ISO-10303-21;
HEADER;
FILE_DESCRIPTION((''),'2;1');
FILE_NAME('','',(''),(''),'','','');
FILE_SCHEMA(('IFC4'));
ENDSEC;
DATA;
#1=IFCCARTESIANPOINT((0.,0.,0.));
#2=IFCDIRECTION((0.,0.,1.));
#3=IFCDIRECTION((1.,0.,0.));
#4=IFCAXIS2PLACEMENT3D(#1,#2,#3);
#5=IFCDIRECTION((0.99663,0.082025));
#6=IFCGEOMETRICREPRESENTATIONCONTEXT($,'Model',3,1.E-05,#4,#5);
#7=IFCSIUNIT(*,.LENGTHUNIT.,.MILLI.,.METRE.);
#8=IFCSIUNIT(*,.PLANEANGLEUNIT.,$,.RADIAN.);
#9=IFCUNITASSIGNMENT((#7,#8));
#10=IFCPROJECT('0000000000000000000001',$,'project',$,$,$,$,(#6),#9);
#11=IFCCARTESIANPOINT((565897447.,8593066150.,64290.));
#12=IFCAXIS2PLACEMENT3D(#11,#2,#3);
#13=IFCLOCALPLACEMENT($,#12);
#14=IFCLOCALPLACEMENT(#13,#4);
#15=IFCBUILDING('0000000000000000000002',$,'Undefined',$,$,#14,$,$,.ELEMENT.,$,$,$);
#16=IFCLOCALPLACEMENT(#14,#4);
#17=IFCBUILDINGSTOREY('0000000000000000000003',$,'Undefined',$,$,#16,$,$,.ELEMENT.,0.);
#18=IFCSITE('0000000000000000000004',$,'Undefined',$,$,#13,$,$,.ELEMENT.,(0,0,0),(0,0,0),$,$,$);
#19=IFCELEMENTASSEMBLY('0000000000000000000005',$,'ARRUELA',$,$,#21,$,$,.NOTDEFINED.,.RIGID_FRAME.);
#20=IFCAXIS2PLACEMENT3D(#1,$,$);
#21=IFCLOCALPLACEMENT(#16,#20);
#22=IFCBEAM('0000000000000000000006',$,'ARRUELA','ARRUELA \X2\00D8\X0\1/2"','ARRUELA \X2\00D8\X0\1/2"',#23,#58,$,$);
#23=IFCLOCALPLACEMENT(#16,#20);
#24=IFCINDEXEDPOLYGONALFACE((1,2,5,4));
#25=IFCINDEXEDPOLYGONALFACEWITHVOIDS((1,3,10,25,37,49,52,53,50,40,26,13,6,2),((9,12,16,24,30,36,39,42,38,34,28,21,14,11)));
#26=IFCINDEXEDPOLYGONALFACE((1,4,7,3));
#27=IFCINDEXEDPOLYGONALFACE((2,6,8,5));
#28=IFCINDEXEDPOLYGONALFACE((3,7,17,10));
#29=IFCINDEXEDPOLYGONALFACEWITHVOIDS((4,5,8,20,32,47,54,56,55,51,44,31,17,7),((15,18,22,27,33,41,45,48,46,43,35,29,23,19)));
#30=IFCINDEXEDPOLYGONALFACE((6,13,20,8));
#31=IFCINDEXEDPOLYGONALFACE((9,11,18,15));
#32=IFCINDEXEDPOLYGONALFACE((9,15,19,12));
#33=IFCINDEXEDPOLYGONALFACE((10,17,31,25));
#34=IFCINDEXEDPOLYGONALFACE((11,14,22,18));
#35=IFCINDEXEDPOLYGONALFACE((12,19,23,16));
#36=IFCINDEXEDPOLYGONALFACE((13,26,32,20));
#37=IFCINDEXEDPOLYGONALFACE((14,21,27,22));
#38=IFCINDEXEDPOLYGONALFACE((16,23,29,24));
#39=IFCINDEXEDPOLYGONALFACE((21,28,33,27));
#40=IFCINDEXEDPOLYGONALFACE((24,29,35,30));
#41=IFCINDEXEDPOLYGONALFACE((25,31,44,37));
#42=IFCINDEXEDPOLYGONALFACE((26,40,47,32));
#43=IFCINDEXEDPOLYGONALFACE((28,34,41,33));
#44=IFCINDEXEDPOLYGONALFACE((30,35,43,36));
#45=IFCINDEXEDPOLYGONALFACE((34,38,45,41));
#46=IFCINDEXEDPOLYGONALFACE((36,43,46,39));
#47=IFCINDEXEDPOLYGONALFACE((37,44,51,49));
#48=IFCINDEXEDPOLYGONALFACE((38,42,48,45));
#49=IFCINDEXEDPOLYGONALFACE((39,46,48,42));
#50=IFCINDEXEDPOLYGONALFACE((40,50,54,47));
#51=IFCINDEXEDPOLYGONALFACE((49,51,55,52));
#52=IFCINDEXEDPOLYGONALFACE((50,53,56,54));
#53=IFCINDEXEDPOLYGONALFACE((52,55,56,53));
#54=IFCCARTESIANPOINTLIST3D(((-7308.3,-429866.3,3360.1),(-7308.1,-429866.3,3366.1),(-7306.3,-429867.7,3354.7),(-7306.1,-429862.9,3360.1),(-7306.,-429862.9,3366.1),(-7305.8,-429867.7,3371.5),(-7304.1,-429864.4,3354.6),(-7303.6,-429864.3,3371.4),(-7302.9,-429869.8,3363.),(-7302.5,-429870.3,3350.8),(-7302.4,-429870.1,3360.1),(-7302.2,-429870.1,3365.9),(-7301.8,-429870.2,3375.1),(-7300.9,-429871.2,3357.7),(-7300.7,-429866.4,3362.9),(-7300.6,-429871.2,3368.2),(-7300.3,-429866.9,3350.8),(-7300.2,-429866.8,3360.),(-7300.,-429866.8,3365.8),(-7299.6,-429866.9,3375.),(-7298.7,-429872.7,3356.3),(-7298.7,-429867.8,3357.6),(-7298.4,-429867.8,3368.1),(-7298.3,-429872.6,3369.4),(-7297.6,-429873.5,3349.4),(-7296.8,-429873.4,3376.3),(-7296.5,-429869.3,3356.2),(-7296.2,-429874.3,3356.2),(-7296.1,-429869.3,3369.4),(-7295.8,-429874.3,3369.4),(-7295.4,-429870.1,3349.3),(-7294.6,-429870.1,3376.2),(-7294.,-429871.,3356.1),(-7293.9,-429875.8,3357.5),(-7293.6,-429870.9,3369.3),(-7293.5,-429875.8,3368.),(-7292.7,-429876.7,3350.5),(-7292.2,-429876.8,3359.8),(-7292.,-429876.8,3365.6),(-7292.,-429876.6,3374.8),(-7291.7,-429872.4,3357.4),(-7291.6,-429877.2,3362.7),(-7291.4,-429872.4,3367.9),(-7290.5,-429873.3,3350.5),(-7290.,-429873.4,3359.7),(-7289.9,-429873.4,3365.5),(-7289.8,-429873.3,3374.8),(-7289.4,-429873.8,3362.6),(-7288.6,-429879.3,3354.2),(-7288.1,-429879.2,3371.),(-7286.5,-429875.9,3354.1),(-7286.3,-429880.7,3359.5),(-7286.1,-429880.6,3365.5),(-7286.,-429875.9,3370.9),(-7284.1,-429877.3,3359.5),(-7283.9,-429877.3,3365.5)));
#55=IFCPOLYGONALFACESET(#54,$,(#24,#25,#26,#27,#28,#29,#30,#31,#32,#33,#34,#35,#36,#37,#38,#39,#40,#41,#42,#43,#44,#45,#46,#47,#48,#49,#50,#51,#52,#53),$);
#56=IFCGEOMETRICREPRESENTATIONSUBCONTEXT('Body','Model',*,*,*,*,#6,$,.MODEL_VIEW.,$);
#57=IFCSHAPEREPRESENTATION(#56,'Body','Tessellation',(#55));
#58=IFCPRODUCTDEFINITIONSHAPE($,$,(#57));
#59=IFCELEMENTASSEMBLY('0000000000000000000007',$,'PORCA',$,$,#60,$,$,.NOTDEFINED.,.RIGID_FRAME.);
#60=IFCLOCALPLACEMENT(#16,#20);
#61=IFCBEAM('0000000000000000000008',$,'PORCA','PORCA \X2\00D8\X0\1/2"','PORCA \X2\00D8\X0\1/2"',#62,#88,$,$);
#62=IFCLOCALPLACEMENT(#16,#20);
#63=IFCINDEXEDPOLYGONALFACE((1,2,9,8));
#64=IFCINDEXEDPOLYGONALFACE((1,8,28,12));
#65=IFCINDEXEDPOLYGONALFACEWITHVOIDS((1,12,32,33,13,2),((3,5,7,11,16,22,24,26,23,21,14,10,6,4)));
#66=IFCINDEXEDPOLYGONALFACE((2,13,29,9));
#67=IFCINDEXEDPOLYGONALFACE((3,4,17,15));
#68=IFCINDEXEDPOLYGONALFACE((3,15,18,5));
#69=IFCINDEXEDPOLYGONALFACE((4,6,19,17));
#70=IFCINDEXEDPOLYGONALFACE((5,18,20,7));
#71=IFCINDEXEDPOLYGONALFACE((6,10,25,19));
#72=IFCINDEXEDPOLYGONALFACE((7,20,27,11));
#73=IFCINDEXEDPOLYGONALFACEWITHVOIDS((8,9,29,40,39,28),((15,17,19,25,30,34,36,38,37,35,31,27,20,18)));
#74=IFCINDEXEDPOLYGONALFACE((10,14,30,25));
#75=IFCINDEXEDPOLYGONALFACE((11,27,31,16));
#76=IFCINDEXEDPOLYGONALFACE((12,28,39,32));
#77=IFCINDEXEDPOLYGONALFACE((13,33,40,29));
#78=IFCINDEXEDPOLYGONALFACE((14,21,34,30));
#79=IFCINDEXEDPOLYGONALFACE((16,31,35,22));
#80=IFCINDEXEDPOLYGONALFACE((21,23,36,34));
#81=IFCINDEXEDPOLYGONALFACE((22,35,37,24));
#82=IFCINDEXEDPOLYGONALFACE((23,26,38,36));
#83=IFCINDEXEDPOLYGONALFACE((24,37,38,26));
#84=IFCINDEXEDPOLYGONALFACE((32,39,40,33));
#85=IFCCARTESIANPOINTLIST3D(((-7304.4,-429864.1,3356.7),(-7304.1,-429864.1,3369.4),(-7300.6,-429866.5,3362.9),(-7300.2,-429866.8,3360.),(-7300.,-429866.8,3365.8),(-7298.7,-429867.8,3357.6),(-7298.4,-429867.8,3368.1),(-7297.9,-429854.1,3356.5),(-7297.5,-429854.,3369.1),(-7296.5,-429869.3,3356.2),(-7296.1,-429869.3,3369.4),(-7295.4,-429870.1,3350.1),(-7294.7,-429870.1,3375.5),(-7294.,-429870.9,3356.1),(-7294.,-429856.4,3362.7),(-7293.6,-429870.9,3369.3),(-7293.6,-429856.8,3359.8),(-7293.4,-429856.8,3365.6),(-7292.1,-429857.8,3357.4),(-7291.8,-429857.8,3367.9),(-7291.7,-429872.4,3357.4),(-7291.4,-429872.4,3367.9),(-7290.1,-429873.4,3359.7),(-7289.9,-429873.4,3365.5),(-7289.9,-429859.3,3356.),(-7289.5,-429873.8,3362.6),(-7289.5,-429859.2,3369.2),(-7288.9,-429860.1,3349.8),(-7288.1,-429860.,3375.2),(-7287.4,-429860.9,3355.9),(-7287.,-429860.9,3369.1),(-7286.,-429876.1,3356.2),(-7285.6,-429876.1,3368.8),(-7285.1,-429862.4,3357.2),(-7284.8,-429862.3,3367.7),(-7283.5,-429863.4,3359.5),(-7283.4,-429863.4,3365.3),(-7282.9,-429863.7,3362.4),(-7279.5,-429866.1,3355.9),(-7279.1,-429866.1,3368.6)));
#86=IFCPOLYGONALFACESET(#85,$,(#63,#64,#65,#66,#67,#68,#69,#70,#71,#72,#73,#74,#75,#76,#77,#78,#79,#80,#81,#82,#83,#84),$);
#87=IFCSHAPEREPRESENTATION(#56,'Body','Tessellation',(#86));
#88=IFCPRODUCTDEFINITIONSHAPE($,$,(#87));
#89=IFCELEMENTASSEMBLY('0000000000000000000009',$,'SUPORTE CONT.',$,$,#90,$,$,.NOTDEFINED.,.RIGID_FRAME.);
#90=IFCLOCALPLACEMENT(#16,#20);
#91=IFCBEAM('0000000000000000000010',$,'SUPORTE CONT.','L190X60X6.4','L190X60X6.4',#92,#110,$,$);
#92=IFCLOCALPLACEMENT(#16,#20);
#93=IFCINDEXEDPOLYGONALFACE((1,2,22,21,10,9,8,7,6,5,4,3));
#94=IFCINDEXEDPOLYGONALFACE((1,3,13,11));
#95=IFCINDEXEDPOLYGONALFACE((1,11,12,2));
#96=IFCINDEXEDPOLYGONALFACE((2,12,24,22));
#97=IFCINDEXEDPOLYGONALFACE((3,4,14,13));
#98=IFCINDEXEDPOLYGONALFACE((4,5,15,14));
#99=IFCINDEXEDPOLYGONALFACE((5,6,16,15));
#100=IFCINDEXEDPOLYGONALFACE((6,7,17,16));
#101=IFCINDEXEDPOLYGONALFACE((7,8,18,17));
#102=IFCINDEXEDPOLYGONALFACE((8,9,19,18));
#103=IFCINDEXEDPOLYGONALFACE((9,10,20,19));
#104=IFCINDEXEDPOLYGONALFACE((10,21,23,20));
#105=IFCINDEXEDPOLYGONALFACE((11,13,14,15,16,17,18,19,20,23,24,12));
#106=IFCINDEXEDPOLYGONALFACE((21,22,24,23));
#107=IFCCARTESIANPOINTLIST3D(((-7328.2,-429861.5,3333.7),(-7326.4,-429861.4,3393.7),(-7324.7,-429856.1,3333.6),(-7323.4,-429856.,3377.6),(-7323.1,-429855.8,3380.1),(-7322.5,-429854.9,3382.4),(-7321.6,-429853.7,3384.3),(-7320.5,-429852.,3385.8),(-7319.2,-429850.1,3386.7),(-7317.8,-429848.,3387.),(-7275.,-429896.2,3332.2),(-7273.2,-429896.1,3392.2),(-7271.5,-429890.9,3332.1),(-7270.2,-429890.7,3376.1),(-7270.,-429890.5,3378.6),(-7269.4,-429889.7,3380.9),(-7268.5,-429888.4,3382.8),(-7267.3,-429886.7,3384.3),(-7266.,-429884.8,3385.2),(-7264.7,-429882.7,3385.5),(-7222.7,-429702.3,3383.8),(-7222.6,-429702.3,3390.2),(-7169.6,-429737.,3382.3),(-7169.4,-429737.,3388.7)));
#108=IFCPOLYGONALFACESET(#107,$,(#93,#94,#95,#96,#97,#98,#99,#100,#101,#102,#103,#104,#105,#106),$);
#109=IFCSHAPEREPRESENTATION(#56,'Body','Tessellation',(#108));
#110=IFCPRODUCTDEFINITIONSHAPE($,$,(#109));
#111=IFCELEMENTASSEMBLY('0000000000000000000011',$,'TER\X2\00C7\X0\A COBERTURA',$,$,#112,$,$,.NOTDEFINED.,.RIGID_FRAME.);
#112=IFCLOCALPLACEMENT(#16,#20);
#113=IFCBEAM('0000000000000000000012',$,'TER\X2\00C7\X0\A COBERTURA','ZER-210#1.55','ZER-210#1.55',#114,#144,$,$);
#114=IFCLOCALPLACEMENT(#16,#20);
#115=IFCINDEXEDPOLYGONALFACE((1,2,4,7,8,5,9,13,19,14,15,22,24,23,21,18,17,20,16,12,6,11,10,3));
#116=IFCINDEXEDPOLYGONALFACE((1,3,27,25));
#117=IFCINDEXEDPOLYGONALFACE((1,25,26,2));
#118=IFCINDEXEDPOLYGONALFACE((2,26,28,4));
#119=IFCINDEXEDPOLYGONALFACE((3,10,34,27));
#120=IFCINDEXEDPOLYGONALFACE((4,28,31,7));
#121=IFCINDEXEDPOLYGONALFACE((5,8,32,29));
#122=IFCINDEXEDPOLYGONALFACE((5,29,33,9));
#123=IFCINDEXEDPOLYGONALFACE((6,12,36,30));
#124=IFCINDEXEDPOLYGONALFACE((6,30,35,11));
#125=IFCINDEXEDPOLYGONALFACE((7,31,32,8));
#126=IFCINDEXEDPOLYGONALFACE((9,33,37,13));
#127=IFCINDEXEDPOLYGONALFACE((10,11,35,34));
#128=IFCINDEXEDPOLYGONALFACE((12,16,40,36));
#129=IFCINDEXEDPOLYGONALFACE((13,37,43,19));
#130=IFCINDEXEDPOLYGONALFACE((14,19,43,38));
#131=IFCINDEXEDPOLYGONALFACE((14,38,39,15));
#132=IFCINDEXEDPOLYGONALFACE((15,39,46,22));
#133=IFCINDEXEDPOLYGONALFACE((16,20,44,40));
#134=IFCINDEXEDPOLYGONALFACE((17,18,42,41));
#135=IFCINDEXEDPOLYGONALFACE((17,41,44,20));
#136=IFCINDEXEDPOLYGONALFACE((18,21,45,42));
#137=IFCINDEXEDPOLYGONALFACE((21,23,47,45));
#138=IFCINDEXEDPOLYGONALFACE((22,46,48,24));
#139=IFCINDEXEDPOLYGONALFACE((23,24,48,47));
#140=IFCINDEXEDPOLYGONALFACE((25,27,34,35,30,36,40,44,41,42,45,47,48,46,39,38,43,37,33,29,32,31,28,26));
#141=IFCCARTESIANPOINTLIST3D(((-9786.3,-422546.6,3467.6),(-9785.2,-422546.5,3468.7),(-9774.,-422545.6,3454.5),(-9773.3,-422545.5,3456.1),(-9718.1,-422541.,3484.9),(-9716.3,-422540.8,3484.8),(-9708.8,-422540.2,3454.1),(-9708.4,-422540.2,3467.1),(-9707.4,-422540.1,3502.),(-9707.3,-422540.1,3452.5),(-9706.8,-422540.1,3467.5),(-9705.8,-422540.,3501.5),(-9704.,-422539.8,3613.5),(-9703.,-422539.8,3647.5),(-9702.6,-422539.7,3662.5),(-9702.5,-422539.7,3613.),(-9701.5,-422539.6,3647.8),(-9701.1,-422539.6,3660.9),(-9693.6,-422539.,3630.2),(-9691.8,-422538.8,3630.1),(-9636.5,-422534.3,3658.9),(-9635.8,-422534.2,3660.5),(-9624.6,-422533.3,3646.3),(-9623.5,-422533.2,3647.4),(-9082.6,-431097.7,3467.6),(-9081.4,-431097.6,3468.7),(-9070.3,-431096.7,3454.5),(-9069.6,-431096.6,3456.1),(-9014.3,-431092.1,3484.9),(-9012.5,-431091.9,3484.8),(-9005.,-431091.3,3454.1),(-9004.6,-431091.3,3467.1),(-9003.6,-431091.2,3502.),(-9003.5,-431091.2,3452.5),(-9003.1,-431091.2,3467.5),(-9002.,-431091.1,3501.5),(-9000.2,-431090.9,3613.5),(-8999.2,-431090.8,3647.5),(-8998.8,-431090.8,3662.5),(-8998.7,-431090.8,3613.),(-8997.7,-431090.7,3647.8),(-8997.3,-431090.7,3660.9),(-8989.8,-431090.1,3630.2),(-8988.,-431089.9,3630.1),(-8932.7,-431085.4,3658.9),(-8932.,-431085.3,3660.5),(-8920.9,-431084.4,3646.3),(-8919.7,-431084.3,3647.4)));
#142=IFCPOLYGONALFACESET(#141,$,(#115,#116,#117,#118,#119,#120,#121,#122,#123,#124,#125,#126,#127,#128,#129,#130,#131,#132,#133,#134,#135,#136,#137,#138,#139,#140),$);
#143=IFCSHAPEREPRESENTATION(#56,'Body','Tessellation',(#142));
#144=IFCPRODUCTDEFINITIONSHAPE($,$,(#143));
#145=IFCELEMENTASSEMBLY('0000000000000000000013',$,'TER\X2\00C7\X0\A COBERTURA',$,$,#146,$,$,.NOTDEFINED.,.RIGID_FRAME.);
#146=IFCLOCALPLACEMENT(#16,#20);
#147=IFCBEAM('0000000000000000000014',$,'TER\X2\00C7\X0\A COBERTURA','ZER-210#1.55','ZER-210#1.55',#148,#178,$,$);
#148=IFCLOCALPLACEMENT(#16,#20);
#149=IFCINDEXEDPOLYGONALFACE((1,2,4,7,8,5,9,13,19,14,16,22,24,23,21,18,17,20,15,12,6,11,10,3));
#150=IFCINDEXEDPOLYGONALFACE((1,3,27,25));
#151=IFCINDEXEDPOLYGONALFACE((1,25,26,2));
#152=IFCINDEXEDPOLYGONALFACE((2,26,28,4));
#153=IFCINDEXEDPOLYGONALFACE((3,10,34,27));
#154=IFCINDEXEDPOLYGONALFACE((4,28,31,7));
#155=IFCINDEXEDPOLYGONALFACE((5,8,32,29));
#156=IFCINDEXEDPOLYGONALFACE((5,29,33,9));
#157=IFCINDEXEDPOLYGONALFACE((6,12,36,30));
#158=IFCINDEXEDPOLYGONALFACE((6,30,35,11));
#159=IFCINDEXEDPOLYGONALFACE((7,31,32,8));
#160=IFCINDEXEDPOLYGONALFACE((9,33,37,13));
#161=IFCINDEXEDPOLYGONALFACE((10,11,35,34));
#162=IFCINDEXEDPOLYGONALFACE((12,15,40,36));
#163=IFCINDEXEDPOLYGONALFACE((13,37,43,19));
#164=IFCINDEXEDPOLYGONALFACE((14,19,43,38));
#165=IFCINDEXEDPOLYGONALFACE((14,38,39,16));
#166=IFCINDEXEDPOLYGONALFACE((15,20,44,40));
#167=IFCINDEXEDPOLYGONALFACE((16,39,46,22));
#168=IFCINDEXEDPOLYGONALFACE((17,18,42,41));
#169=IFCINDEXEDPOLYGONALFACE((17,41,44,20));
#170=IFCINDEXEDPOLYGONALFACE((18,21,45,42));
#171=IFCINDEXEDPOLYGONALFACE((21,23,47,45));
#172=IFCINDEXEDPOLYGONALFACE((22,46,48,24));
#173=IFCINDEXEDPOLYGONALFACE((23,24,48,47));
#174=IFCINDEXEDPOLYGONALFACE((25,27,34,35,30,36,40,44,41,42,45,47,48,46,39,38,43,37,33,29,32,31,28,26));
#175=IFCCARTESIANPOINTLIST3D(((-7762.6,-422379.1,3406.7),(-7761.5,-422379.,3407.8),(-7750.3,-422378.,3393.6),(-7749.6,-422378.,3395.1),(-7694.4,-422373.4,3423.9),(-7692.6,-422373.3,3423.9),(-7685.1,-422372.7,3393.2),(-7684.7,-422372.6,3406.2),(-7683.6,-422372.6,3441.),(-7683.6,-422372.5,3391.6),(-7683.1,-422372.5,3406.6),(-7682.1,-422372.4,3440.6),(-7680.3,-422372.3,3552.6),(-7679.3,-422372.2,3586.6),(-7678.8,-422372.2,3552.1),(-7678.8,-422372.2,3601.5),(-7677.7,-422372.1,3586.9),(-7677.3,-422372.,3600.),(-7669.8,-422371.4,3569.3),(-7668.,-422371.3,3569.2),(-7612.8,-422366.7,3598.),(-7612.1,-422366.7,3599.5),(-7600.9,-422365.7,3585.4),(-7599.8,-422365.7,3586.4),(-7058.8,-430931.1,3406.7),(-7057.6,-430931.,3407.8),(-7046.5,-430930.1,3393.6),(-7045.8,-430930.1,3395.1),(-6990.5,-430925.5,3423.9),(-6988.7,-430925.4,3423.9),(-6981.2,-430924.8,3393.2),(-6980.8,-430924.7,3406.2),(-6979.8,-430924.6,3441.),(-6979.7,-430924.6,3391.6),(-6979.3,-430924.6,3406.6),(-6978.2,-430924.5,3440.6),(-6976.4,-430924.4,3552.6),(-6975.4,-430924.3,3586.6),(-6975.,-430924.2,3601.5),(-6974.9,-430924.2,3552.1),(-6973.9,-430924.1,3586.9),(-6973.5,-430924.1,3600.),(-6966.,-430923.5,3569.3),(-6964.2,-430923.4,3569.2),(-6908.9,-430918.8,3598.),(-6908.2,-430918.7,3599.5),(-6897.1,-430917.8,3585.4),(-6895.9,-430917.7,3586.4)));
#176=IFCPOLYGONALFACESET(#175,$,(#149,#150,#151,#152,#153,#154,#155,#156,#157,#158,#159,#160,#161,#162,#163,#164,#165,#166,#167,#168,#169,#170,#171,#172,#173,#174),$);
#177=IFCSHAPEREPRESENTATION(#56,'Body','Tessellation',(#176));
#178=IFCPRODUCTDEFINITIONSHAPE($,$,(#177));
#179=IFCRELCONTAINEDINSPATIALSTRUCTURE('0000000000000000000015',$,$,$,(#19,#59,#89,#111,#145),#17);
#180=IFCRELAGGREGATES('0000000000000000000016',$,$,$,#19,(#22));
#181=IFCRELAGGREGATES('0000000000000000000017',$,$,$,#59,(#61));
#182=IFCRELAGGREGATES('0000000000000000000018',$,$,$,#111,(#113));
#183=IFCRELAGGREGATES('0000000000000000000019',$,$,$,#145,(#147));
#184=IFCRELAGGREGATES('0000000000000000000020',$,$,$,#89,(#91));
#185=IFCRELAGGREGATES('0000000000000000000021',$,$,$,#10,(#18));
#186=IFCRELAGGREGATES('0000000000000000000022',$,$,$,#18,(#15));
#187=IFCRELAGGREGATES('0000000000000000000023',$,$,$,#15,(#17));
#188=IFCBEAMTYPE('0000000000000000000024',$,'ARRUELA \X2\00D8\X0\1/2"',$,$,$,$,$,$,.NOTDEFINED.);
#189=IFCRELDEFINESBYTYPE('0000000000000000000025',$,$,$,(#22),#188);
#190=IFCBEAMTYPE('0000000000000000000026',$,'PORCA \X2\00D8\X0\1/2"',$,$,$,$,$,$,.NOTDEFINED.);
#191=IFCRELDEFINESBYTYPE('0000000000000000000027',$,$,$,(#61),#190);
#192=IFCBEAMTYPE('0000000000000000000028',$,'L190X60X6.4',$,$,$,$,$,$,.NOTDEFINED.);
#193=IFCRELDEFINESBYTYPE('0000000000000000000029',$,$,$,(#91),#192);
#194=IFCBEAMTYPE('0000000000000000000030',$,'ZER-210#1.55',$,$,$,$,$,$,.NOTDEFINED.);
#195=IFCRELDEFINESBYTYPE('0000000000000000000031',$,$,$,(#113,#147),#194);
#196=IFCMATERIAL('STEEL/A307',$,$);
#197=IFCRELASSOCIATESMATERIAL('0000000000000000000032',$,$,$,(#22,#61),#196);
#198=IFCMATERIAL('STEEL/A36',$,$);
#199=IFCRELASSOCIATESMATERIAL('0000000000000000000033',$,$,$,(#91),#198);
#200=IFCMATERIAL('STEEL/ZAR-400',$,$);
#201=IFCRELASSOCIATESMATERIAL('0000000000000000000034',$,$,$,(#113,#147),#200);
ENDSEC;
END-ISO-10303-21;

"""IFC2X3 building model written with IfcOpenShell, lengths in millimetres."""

from ifc_helpers import new_model, si_unit, direction, frame, origin_with_axes, origin_2d_with_axis, place, context, subcontext, project, spatial, polyline, l_section, outline, extrude, material, type_object, element, aggregate, save


model = new_model("IFC2X3")

# Units and contexts
model_context = context("Model", 3, precision=1e-05, world=origin_with_axes(), true_north=direction((0.99663, 0.082025)))
body_context = subcontext(model_context, "Body", "Model", "MODEL_VIEW")
ifc_project = project(units=[si_unit("LENGTHUNIT", "METRE", prefix="MILLI"), si_unit("PLANEANGLEUNIT", "RADIAN")], contexts=[model_context])

# Site, building, storey
site_placement = place(None, frame((565897447.0, 8593066150.0, 64290.0), z_axis=(0.0, 0.0, 1.0), x_axis=(1.0, 0.0, 0.0)))
site = spatial("IfcSite", under=ifc_project, at=site_placement, Name="Undefined", CompositionType="ELEMENT", RefLatitude=(0, 0, 0), RefLongitude=(0, 0, 0))
building_placement = place(site_placement, origin_with_axes())
building = spatial("IfcBuilding", under=site, at=building_placement, Name="Undefined", CompositionType="ELEMENT")
storey_placement = place(building_placement, origin_with_axes())
storey = spatial("IfcBuildingStorey", under=building, at=storey_placement, Name="Undefined", CompositionType="ELEMENT", Elevation=0.0)

# Element assemblies, beams
ifc_material_1 = material(Name="STEEL/ZAR-400")
ifc_material_2 = material(Name="STEEL/A36")
assembly_1_placement = place(storey_placement, origin_with_axes())
assembly_1 = element("IfcElementAssembly", 1, at=assembly_1_placement, inside=storey, Name="ARRUELA", AssemblyPlace="NOTDEFINED", PredefinedType="RIGID_FRAME")
ifc_material_3 = material(Name="STEEL/A307")
beam_type_1 = type_object("IfcBeamType", Name="ARRUELA Ø1/2\"", PredefinedType="NOTDEFINED")
beam_1_placement = place(assembly_1_placement, frame((-7295.0, -429870.1, 3362.8), z_axis=(-0.836984, 0.546715, 0.02368), x_axis=(-0.546411, -0.837315, 0.018398)))
beam_1 = element("IfcBeam", 2, at=beam_1_placement, type_object=beam_type_1, material=ifc_material_3, Name="ARRUELA", Description="ARRUELA Ø1/2\"", ObjectType="ARRUELA Ø1/2\"", context=body_context, shape_type="SweptSolid", body=[
    extrude(outline(polyline([(-12.2, 5.9), (-8.4, 10.5), (-3.0, 13.2), (3.0, 13.2), (8.4, 10.5), (12.2, 5.9), (13.5, 0.0), (12.2, -5.9), (8.4, -10.5), (3.0, -13.2), (-3.0, -13.2), (-8.4, -10.5), (-12.2, -5.9), (-13.5, 0.0), (-12.2, 5.9)]), holes=[polyline([(5.3, 4.2), (2.9, 6.1), (0.0, 6.8), (-2.9, 6.1), (-5.3, 4.2), (-6.6, 1.5), (-6.6, -1.5), (-5.3, -4.2), (-2.9, -6.1), (0.0, -6.7), (2.9, -6.1), (5.3, -4.2), (6.6, -1.5), (6.6, 1.5), (5.3, 4.2)])]), frame((4.0, 0.0, 0.0), z_axis=(-1.0, 0.0, 0.0), x_axis=(0.0, -1.0, 0.0)), (0.0, 0.0, 1.0), 4.0),
])
aggregate(assembly_1, [beam_1])
assembly_2_placement = place(storey_placement, origin_with_axes())
assembly_2 = element("IfcElementAssembly", 3, at=assembly_2_placement, inside=storey, Name="PORCA", AssemblyPlace="NOTDEFINED", PredefinedType="RIGID_FRAME")
beam_type_2 = type_object("IfcBeamType", Name="PORCA Ø1/2\"", PredefinedType="NOTDEFINED")
beam_2_placement = place(assembly_2_placement, frame((-7288.5, -429860.1, 3362.5), z_axis=(-0.836984, 0.546715, 0.02368), x_axis=(-0.546411, -0.837315, 0.018398)))
beam_2 = element("IfcBeam", 4, at=beam_2_placement, type_object=beam_type_2, material=ifc_material_3, Name="PORCA", Description="PORCA Ø1/2\"", ObjectType="PORCA Ø1/2\"", context=body_context, shape_type="SweptSolid", body=[
    extrude(outline(polyline([(-6.3, -11.0), (-12.7, 0.0), (-6.3, 11.0), (6.3, 11.0), (12.7, 0.0), (6.3, -11.0), (-6.3, -11.0)]), holes=[polyline([(5.3, 4.2), (2.9, 6.0), (0.0, 6.7), (-2.9, 6.0), (-5.3, 4.2), (-6.6, 1.5), (-6.6, -1.5), (-5.3, -4.2), (-2.9, -6.0), (0.0, -6.7), (2.9, -6.0), (5.3, -4.2), (6.6, -1.5), (6.6, 1.5), (5.3, 4.2)])]), frame((12.0, 0.0, 0.0), z_axis=(-1.0, 0.0, 0.0), x_axis=(0.0, -1.0, 0.0)), (0.0, 0.0, 1.0), 12.0),
])
aggregate(assembly_2, [beam_2])
assembly_3_placement = place(storey_placement, origin_with_axes())
assembly_3 = element("IfcElementAssembly", 5, at=assembly_3_placement, inside=storey, Name="SUPORTE CONT.", AssemblyPlace="NOTDEFINED", PredefinedType="RIGID_FRAME")
beam_type_3 = type_object("IfcBeamType", Name="L190X60X6.4", PredefinedType="NOTDEFINED")
beam_3_placement = place(assembly_3_placement, frame((-7222.2, -429816.6, 3360.5), z_axis=(0.546411, 0.837315, -0.018398), x_axis=(-0.836984, 0.546715, 0.02368)))
beam_3 = element("IfcBeam", 6, at=beam_3_placement, type_object=beam_type_3, material=ifc_material_2, Name="SUPORTE CONT.", Description="L190X60X6.4", ObjectType="L190X60X6.4", context=body_context, shape_type="SweptSolid", body=[
    extrude(l_section(Depth=190.0, Width=60.0, Thickness=6.4, FilletRadius=9.6, at=origin_2d_with_axis()), frame((63.5, 0.0, 0.0), z_axis=(-1.0, 0.0, 0.0), x_axis=(0.0, -1.0, 0.0)), (0.0, 0.0, 1.0), 63.5),
])
assembly_4_placement = place(storey_placement, origin_with_axes())
assembly_4 = element("IfcElementAssembly", 7, at=assembly_4_placement, inside=storey, Name="TERÇA COBERTURA", AssemblyPlace="NOTDEFINED", PredefinedType="RIGID_FRAME")
beam_type_4 = type_object("IfcBeamType", Name="ZER-210#1.55", PredefinedType="NOTDEFINED")
beam_4_placement = place(assembly_4_placement, frame((-9704.9, -422539.9, 3557.5), z_axis=(0.029885, 0.00246, 0.99955), x_axis=(0.082025, -0.99663, 0.0)))
beam_4 = element("IfcBeam", 8, at=beam_4_placement, type_object=beam_type_4, material=ifc_material_1, Name="TERÇA COBERTURA", Description="ZER-210#1.55", ObjectType="ZER-210#1.55", context=body_context, shape_type="SweptSolid", body=[
    extrude(outline(polyline([(-65.6, 103.4), (-77.9, 91.2), (-79.0, 92.3), (-66.2, 105.0), (0.8, 105.0), (0.8, 90.0), (-9.2, 73.0), (0.8, 56.0), (0.8, -55.6), (11.0, -73.0), (0.8, -90.4), (0.8, -103.5), (65.6, -103.4), (77.9, -91.2), (79.0, -92.3), (66.2, -105.0), (-0.8, -105.0), (-0.8, -90.0), (9.2, -73.0), (-0.8, -56.0), (-0.8, 55.6), (-11.0, 73.0), (-0.8, 90.4), (-0.8, 103.5), (-65.6, 103.4)])), frame((8580.0, 0.0, 0.0), z_axis=(-1.0, 0.0, 0.0), x_axis=(0.0, -1.0, 0.0)), (0.0, 0.0, 1.0), 8580.0),
])
aggregate(assembly_4, [beam_4])
assembly_5_placement = place(storey_placement, origin_with_axes())
assembly_5 = element("IfcElementAssembly", 9, at=assembly_5_placement, inside=storey, Name="TERÇA COBERTURA", AssemblyPlace="NOTDEFINED", PredefinedType="RIGID_FRAME")
beam_5_placement = place(assembly_5_placement, frame((-7681.2, -422372.4, 3496.6), z_axis=(0.029885, 0.00246, 0.99955), x_axis=(0.082025, -0.99663, 0.0)))
beam_5 = element("IfcBeam", 10, at=beam_5_placement, type_object=beam_type_4, material=ifc_material_1, Name="TERÇA COBERTURA", Description="ZER-210#1.55", ObjectType="ZER-210#1.55", context=body_context, shape_type="SweptSolid", body=[
    extrude(outline(polyline([(-65.6, 103.4), (-77.9, 91.2), (-79.0, 92.3), (-66.2, 105.0), (0.8, 105.0), (0.8, 90.0), (-9.2, 73.0), (0.8, 56.0), (0.8, -55.6), (11.0, -73.0), (0.8, -90.4), (0.8, -103.5), (65.6, -103.4), (77.9, -91.2), (79.0, -92.3), (66.2, -105.0), (-0.8, -105.0), (-0.8, -90.0), (9.2, -73.0), (-0.8, -56.0), (-0.8, 55.6), (-11.0, 73.0), (-0.8, 90.4), (-0.8, 103.5), (-65.6, 103.4)])), frame((8581.0, 0.0, 0.0), z_axis=(-1.0, 0.0, 0.0), x_axis=(0.0, -1.0, 0.0)), (0.0, 0.0, 1.0), 8581.0),
])
aggregate(assembly_5, [beam_5])

aggregate(assembly_3, [beam_3])

save(model, "model.ifc")
